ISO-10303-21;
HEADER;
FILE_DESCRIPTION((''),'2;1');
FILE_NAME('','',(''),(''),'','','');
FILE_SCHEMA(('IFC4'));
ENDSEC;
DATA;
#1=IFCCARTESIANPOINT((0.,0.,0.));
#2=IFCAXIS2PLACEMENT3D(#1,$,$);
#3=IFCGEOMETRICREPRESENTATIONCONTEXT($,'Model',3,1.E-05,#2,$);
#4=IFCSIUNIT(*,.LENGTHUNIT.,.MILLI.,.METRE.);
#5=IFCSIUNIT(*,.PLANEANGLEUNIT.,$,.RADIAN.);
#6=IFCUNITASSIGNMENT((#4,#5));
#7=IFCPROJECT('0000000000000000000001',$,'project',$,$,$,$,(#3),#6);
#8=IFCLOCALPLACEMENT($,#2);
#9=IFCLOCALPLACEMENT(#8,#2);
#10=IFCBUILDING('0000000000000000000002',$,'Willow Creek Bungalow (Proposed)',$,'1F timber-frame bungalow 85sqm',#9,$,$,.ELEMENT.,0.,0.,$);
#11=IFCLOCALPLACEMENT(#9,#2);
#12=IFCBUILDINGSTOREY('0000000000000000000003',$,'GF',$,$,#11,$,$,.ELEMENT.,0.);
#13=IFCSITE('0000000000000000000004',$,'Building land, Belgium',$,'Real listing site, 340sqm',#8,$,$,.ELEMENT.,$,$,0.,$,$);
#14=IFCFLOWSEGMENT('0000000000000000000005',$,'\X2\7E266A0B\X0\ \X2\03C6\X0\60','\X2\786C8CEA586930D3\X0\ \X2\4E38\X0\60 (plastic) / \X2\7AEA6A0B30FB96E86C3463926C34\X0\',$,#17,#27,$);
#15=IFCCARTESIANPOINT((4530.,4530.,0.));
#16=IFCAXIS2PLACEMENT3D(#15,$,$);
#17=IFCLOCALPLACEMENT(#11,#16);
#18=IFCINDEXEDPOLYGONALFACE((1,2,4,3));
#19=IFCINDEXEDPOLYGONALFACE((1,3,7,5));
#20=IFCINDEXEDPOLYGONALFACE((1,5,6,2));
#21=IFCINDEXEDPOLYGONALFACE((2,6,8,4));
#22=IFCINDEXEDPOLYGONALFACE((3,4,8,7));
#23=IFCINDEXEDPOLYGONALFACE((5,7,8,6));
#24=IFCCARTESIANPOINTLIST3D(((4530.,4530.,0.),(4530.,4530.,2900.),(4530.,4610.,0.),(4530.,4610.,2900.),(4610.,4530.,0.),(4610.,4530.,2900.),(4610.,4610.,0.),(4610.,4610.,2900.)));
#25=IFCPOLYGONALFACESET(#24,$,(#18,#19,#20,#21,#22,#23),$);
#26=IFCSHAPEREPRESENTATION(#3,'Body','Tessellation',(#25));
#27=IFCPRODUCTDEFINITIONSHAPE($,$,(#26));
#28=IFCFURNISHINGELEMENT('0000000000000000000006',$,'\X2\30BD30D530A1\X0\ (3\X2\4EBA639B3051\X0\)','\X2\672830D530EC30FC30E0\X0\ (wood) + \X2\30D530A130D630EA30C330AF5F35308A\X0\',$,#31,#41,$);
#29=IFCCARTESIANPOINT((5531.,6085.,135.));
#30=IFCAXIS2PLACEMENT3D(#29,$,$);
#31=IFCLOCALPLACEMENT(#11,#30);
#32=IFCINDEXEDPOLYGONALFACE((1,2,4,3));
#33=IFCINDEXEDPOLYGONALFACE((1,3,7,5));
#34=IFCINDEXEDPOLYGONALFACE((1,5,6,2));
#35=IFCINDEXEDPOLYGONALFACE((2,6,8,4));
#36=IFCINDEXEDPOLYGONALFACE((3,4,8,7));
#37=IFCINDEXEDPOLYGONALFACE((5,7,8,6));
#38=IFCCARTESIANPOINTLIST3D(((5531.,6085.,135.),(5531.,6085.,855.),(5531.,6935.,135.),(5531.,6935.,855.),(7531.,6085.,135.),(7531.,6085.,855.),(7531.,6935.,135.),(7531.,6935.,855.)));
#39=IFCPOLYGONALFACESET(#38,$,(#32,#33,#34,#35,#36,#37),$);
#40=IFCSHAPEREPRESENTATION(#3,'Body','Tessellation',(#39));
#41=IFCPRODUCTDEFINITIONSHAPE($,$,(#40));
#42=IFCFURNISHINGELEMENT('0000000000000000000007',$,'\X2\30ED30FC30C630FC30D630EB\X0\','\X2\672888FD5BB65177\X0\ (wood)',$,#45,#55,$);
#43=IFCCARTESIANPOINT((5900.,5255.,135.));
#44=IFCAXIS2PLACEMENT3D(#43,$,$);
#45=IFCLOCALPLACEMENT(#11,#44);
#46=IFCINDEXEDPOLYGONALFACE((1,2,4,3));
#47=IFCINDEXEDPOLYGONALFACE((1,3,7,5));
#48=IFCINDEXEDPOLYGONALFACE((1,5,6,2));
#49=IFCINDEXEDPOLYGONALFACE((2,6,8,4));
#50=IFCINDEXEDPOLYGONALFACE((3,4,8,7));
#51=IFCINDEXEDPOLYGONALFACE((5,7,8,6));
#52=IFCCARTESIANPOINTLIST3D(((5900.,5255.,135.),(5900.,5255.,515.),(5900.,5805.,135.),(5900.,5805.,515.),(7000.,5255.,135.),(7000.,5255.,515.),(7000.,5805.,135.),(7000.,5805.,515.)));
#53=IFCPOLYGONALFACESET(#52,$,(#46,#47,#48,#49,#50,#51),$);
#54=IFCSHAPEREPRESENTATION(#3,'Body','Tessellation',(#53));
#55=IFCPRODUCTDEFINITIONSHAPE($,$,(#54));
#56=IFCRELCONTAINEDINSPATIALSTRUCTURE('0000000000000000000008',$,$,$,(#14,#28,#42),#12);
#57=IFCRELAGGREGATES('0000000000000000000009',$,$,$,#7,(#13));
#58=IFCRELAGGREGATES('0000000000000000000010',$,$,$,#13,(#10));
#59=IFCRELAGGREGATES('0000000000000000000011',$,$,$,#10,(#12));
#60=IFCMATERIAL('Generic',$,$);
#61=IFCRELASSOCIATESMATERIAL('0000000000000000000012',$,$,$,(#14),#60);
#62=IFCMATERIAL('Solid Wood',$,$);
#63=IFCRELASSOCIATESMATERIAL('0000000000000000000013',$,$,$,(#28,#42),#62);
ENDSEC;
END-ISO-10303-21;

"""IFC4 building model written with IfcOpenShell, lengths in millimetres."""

from ifc_helpers import new_model, si_unit, frame, frame_2d, origin, place, context, project, spatial, rectangle, extrude, material, element, save


model = new_model("IFC4")

# Units and contexts
model_context = context("Model", 3, precision=1e-05, world=origin())
ifc_project = project(units=[si_unit("LENGTHUNIT", "METRE", prefix="MILLI"), si_unit("PLANEANGLEUNIT", "RADIAN")], contexts=[model_context])

# Site, building, storey
site_placement = place(None, origin())
site = spatial("IfcSite", under=ifc_project, at=site_placement, Name="Building land, Belgium", ObjectType="Real listing site, 340sqm", CompositionType="ELEMENT", RefElevation=0.0)
building_placement = place(site_placement, origin())
building = spatial("IfcBuilding", under=site, at=building_placement, Name="Willow Creek Bungalow (Proposed)", ObjectType="1F timber-frame bungalow 85sqm", CompositionType="ELEMENT", ElevationOfRefHeight=0.0, ElevationOfTerrain=0.0)
storey_placement = place(building_placement, origin())
storey = spatial("IfcBuildingStorey", under=building, at=storey_placement, Name="GF", CompositionType="ELEMENT", Elevation=0.0)

# Shared definitions
ifc_material_1 = material(Name="Solid Wood")

# Shared definitions
ifc_material_2 = material(Name="Generic")

# Flow segment
flow_segment_1_placement = place(storey_placement, frame((4530.0, 4530.0, 0.0)))
element("IfcFlowSegment", 1, at=flow_segment_1_placement, inside=storey, material=ifc_material_2, Name="縦樋 φ60", Description="硬質塩ビ 丸60 (plastic) / 竪樋・雨水排水", context=model_context, shape_type="SweptSolid", body=[
    extrude(rectangle(XDim=80.0, YDim=80.0, at=frame_2d((40.0, 40.0))), frame((4530.0, 4530.0, 0.0)), (0.0, 0.0, 1.0), 2900.0),
])

# Furnishing elements
furnishing_1_placement = place(storey_placement, frame((5531.0, 6085.0, 135.0)))
element("IfcFurnishingElement", 2, at=furnishing_1_placement, inside=storey, material=ifc_material_1, Name="ソファ (3人掛け)", Description="木フレーム (wood) + ファブリック張り", context=model_context, shape_type="SweptSolid", body=[
    extrude(rectangle(XDim=2000.0, YDim=850.0, at=frame_2d((1000.0, 425.0))), frame((5531.0, 6085.0, 135.0)), (0.0, 0.0, 1.0), 720.0),
])
furnishing_2_placement = place(storey_placement, frame((5900.0, 5255.0, 135.0)))
element("IfcFurnishingElement", 3, at=furnishing_2_placement, inside=storey, material=ifc_material_1, Name="ローテーブル", Description="木製家具 (wood)", context=model_context, shape_type="SweptSolid", body=[
    extrude(rectangle(XDim=1100.0, YDim=550.0, at=frame_2d((550.0, 275.0))), frame((5900.0, 5255.0, 135.0)), (0.0, 0.0, 1.0), 380.0),
])

save(model, "model.ifc")
